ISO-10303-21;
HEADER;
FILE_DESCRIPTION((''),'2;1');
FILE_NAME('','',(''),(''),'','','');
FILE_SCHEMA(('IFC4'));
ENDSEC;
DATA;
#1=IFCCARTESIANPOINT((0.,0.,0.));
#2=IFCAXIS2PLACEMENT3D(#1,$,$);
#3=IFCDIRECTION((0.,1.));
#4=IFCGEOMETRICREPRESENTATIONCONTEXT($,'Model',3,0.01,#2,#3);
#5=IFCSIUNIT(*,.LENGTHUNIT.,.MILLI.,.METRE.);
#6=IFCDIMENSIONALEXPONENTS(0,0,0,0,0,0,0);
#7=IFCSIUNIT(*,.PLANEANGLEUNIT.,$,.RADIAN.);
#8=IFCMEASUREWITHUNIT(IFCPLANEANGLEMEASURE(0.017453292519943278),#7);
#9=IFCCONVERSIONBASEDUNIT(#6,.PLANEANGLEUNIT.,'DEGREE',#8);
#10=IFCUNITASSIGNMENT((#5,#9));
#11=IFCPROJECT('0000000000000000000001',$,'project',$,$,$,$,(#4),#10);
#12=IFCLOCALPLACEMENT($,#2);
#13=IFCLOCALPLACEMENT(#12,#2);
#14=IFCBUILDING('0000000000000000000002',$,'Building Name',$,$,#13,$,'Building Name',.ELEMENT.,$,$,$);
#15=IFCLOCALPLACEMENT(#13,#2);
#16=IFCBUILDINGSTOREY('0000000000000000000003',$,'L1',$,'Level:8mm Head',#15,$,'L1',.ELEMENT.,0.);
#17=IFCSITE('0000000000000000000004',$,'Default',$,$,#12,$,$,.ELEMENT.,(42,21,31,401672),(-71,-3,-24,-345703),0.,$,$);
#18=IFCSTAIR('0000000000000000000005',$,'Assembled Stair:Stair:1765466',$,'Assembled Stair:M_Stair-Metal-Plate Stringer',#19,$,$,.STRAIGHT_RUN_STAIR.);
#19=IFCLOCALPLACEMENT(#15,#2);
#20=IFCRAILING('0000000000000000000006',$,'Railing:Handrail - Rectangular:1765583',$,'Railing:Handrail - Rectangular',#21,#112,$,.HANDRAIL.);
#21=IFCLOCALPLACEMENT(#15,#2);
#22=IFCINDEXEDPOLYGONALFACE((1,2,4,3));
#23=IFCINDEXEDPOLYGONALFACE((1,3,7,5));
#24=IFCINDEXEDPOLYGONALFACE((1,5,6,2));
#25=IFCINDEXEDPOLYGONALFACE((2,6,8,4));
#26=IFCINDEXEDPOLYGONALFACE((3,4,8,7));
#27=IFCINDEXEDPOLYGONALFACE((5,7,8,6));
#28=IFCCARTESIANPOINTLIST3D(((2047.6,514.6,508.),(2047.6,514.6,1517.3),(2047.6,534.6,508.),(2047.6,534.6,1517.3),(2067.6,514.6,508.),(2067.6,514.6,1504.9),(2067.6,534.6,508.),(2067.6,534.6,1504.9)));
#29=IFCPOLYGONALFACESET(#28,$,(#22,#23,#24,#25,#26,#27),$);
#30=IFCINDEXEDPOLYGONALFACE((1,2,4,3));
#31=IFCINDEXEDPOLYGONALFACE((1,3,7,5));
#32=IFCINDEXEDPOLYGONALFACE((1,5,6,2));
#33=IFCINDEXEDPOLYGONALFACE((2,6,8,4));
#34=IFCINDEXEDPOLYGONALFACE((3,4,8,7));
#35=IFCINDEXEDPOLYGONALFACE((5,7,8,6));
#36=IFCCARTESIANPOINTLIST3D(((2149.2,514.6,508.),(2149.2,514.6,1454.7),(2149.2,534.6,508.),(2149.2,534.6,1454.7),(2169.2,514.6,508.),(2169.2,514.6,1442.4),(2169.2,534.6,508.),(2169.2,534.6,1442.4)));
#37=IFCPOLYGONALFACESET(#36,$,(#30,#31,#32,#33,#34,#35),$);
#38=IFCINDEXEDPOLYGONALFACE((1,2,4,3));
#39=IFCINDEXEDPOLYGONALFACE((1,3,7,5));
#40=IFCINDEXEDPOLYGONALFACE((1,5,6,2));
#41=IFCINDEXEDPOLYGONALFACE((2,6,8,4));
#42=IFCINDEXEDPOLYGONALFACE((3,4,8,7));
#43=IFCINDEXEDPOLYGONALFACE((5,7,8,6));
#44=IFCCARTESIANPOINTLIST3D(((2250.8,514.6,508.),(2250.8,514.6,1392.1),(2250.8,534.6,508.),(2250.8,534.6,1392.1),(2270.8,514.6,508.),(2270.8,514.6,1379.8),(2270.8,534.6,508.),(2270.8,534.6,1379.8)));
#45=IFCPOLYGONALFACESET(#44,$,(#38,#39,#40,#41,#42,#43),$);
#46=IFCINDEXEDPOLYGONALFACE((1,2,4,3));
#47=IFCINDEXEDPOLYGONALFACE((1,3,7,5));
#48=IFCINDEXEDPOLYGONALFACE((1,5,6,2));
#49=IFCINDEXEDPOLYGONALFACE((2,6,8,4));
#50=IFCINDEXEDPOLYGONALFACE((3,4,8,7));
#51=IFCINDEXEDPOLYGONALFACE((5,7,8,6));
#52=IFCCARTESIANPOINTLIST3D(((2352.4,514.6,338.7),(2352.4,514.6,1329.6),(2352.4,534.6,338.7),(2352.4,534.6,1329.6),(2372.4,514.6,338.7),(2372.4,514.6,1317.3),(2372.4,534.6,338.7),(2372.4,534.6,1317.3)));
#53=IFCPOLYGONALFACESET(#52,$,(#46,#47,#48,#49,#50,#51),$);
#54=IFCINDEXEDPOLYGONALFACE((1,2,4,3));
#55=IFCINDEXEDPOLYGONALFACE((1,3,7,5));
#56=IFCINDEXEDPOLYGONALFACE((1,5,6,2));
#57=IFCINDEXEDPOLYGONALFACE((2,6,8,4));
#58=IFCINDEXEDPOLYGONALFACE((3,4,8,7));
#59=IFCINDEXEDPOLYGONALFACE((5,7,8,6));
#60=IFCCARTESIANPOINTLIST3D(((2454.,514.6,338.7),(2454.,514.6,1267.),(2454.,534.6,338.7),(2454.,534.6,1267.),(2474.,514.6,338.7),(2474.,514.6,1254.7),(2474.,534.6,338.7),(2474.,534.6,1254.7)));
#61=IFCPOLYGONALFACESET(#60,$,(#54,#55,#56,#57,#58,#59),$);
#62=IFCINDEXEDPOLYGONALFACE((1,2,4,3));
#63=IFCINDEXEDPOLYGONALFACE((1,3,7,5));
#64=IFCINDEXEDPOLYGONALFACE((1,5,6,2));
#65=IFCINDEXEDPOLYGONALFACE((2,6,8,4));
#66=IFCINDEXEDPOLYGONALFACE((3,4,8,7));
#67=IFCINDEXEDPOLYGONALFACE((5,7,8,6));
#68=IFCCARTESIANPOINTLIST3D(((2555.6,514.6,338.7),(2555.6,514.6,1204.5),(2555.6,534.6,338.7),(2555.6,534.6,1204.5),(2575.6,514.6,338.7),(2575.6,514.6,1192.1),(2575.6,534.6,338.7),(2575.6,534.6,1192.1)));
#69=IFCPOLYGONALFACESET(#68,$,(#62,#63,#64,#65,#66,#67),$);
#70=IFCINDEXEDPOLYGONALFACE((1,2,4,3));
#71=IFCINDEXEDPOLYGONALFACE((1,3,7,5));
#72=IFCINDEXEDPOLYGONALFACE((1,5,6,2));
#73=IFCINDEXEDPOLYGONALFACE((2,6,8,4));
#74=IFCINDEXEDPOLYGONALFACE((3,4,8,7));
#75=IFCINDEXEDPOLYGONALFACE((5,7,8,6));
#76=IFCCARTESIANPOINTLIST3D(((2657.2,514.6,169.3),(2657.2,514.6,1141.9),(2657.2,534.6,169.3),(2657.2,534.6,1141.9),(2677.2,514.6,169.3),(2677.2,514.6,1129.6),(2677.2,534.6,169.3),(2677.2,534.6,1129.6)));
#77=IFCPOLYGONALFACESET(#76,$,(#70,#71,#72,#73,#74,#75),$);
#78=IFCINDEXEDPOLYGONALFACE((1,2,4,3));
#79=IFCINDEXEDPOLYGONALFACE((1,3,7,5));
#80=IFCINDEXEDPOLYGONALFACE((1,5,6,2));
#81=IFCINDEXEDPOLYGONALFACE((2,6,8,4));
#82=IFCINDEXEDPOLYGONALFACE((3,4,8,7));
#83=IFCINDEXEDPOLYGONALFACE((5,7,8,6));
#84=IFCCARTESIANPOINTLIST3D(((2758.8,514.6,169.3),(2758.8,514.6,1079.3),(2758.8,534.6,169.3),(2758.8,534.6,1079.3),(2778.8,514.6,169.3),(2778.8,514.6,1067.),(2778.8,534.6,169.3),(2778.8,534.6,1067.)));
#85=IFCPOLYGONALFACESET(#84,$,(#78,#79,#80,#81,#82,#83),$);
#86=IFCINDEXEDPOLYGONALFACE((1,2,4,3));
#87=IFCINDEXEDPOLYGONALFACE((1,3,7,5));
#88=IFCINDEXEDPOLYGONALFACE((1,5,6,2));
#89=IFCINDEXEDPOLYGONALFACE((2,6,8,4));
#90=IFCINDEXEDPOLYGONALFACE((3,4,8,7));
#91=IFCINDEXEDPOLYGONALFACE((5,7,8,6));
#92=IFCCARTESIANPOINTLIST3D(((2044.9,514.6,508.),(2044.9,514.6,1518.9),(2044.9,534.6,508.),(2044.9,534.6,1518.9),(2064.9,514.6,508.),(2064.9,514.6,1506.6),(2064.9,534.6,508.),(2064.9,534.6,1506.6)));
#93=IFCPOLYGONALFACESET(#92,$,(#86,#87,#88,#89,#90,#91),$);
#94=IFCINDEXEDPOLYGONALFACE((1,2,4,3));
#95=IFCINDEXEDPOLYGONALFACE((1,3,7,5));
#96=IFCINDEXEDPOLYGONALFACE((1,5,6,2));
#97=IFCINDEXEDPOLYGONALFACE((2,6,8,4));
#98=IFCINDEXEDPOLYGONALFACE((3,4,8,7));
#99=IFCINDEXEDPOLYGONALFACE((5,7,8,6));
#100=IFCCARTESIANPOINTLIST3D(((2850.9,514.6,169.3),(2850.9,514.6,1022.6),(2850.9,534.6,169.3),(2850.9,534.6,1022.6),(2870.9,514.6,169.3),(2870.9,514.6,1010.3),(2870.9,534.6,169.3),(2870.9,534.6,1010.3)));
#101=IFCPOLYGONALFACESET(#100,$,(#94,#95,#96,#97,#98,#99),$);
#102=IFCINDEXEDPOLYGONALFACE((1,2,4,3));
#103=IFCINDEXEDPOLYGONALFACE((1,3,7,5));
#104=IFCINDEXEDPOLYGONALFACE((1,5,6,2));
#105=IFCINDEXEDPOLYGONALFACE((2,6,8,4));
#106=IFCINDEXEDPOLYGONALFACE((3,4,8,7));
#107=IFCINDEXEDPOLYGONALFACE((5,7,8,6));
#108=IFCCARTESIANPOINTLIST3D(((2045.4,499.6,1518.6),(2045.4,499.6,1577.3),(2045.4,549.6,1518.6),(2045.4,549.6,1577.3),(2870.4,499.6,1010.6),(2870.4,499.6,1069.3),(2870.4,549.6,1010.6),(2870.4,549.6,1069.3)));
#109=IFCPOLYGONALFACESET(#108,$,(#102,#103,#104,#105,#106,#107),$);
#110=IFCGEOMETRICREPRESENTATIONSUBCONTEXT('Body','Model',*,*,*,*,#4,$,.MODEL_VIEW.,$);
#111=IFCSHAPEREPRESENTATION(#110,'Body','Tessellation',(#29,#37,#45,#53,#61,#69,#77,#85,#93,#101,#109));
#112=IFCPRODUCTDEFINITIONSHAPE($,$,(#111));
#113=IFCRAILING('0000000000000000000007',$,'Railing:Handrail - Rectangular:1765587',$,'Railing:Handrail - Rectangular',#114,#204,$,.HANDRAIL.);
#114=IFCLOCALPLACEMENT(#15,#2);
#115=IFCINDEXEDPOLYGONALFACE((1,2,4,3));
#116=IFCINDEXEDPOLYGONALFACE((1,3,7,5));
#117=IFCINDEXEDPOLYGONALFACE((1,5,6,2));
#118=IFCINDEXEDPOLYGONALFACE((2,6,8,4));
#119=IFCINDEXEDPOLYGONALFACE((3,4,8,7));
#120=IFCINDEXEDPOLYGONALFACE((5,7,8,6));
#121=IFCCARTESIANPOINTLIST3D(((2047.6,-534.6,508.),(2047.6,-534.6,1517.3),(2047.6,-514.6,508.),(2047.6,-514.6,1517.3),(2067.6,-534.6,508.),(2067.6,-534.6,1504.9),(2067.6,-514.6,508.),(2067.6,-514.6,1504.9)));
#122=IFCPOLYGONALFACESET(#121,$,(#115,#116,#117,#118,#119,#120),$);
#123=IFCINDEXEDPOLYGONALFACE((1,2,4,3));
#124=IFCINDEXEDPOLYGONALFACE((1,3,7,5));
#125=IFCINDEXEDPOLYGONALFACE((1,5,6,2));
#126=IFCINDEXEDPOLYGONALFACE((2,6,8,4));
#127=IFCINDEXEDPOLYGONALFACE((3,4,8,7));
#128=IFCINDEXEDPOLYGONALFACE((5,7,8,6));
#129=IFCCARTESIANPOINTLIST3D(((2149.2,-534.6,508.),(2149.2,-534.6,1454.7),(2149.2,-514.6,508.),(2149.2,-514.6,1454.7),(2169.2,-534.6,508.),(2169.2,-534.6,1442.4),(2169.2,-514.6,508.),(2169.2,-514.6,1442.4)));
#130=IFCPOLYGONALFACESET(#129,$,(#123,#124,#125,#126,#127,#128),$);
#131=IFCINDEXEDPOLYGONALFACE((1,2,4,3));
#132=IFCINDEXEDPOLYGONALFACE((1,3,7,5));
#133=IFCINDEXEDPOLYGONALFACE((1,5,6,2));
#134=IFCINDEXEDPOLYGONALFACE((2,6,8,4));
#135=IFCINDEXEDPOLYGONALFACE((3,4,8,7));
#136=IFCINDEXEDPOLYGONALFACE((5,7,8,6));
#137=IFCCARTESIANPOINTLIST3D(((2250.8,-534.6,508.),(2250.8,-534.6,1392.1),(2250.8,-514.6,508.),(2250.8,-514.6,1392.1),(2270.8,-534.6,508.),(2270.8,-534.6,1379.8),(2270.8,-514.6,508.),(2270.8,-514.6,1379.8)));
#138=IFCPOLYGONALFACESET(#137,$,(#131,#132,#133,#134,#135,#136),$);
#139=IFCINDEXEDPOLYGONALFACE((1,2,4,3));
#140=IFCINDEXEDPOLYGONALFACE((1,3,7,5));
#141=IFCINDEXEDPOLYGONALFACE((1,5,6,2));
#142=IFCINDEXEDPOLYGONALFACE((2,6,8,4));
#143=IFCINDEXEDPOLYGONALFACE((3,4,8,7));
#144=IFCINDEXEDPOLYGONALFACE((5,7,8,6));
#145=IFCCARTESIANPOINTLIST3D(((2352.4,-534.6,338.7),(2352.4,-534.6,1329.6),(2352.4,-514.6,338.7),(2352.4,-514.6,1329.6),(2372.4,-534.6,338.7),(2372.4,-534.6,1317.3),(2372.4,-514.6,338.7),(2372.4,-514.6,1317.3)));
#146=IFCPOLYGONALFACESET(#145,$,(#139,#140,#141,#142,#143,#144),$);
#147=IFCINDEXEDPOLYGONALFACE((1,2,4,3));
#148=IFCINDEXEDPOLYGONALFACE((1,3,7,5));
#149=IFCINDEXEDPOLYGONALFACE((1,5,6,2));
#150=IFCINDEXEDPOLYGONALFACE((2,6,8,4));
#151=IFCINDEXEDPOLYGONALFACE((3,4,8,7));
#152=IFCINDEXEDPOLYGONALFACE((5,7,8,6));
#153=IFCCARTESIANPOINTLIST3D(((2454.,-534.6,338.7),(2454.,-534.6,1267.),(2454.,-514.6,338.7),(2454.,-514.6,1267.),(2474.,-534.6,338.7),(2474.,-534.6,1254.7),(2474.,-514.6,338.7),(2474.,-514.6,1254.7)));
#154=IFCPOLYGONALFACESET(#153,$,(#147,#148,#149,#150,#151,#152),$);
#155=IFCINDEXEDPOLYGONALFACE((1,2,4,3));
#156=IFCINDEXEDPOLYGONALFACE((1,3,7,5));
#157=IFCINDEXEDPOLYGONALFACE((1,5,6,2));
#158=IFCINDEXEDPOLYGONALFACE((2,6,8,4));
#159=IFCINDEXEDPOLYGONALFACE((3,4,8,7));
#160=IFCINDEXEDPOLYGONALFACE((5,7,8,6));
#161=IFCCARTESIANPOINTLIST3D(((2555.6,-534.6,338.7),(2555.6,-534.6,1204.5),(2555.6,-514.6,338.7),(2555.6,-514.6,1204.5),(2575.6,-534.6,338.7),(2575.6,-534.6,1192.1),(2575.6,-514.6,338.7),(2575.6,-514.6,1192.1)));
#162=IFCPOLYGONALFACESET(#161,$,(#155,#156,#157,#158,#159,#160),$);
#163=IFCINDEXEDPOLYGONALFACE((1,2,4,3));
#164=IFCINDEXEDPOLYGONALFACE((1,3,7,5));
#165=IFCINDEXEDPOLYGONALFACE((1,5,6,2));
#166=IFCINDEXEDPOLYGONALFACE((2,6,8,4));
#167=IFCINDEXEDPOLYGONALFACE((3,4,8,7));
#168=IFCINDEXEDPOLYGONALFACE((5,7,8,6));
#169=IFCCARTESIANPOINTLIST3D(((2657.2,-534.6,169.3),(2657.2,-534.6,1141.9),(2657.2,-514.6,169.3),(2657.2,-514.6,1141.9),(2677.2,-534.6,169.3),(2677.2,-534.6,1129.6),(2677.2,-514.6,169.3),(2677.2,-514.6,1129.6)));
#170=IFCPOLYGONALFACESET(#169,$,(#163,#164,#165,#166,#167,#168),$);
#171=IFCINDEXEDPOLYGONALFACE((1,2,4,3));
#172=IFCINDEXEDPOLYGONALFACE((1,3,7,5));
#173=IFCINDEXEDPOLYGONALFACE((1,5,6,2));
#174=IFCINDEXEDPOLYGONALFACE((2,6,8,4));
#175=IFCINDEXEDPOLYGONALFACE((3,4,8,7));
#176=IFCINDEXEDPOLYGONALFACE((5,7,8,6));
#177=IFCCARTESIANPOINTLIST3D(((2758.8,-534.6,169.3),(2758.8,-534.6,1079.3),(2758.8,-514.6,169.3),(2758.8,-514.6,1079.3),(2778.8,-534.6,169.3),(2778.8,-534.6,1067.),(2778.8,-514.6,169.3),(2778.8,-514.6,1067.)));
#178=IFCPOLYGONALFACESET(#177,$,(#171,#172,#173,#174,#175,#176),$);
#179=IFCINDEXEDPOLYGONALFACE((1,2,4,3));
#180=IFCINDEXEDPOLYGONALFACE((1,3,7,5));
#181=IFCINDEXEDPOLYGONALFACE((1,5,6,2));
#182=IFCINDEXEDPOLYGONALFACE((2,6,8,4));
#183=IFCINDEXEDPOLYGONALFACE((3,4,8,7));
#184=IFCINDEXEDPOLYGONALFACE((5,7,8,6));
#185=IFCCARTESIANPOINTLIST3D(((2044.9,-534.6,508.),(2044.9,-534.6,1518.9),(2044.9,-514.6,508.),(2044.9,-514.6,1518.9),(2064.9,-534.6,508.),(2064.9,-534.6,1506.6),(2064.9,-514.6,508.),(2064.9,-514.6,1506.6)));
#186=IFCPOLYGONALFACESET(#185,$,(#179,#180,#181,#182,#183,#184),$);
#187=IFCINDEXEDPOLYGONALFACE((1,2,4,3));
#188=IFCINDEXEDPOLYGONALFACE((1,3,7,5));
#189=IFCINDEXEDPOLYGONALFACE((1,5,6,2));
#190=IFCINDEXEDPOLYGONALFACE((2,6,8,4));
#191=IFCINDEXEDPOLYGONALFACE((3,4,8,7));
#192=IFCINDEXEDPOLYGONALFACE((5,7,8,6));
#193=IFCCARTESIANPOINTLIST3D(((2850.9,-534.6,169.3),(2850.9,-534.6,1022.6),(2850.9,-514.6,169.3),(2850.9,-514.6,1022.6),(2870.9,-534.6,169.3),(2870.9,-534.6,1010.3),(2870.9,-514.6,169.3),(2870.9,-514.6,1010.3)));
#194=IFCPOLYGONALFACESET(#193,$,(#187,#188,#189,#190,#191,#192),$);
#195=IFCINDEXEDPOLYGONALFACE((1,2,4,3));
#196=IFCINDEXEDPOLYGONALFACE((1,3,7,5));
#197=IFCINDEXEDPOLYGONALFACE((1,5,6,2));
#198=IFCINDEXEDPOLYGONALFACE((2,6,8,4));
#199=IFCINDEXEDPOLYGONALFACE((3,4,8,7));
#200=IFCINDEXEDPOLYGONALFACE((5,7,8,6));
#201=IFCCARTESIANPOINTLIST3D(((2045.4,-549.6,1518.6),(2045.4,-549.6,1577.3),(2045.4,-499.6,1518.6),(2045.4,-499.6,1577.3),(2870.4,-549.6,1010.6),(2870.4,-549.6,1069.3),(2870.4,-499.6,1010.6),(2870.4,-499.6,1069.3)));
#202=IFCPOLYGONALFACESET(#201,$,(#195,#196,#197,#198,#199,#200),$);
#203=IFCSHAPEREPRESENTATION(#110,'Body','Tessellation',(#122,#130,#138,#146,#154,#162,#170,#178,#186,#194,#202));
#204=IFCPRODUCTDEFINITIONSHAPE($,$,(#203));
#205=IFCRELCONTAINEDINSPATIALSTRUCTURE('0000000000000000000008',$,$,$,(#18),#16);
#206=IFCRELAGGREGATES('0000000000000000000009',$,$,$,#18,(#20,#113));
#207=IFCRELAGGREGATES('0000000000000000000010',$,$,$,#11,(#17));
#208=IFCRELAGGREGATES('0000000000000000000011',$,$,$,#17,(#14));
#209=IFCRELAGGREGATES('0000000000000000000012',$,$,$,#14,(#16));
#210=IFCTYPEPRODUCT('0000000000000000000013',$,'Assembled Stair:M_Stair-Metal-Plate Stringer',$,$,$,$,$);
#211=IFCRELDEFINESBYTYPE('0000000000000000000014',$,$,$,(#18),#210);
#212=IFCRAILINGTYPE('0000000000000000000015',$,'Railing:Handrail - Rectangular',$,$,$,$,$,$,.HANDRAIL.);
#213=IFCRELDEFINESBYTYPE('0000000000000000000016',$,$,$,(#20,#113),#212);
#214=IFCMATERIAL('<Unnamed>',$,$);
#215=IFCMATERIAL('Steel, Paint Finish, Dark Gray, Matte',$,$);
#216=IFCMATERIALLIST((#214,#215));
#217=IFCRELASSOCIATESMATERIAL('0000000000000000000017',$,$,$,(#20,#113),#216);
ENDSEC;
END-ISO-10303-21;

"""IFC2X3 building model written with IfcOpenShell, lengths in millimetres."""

from ifc_helpers import new_model, entity, si_unit, converted_unit, direction, frame, origin, place, context, subcontext, project, spatial, polyline, outline, extrude, material, material_list, type_object, element, aggregate, save


model = new_model("IFC2X3")

# Units and contexts
model_context = context("Model", 3, precision=0.01, world=origin(), true_north=direction((0.0, 1.0)))
body_context = subcontext(model_context, "Body", "Model", "MODEL_VIEW")
ifc_project = project(units=[si_unit("LENGTHUNIT", "METRE", prefix="MILLI"), converted_unit("PLANEANGLEUNIT", "DEGREE", entity("IfcPlaneAngleMeasure", 0.017453292519943278), si_unit("PLANEANGLEUNIT", "RADIAN"), dimensions=[0, 0, 0, 0, 0, 0, 0])], contexts=[model_context])

# Site, building, storey
site_placement = place(None, origin())
site = spatial("IfcSite", under=ifc_project, at=site_placement, Name="Default", CompositionType="ELEMENT", RefLatitude=(42, 21, 31, 401672), RefLongitude=(-71, -3, -24, -345703), RefElevation=0.0)
building_placement = place(site_placement, origin())
building = spatial("IfcBuilding", under=site, at=building_placement, Name="Building Name", LongName="Building Name", CompositionType="ELEMENT")
storey_placement = place(building_placement, origin())
storey = spatial("IfcBuildingStorey", under=building, at=storey_placement, Name="L1", ObjectType="Level:8mm Head", LongName="L1", CompositionType="ELEMENT", Elevation=0.0)

# Stair
type_product = type_object("IfcTypeProduct", Name="Assembled Stair:M_Stair-Metal-Plate Stringer")
stair_1_placement = place(storey_placement, origin())
stair_1 = element("IfcStair", 1, at=stair_1_placement, inside=storey, type_object=type_product, Name="Assembled Stair:Stair:1765466", ObjectType="Assembled Stair:M_Stair-Metal-Plate Stringer", ShapeType="STRAIGHT_RUN_STAIR")

# Railings
ifc_material_1 = material(Name="<Unnamed>")
ifc_material_2 = material(Name="Steel, Paint Finish, Dark Gray, Matte")
ifc_material_list = material_list([ifc_material_1, ifc_material_2])
railing_type = type_object("IfcRailingType", Name="Railing:Handrail - Rectangular", PredefinedType="HANDRAIL")
railing_1_placement = place(stair_1_placement, origin())
railing_1 = element("IfcRailing", 2, at=railing_1_placement, type_object=railing_type, material=ifc_material_list, Name="Railing:Handrail - Rectangular:1765583", ObjectType="Railing:Handrail - Rectangular", PredefinedType="HANDRAIL", context=body_context, shape_type="SweptSolid", body=[
    extrude(outline(polyline([(-10.0, -501.6), (10.0, -501.6), (10.0, 507.7), (-10.0, 495.4), (-10.0, -501.6)])), frame((2057.6, 514.6, 1009.6), z_axis=(0.0, 1.0, 0.0), x_axis=(-1.0, 0.0, 0.0)), (0.0, 0.0, 1.0), 20.0),
    extrude(outline(polyline([(-10.0, -470.3), (10.0, -470.3), (10.0, 476.4), (-10.0, 464.1), (-10.0, -470.3)])), frame((2159.2, 514.6, 978.3), z_axis=(0.0, 1.0, 0.0), x_axis=(-1.0, 0.0, 0.0)), (0.0, 0.0, 1.0), 20.0),
    extrude(outline(polyline([(-10.0, -439.0), (10.0, -439.0), (10.0, 445.1), (-10.0, 432.8), (-10.0, -439.0)])), frame((2260.8, 514.6, 947.0), z_axis=(0.0, 1.0, 0.0), x_axis=(-1.0, 0.0, 0.0)), (0.0, 0.0, 1.0), 20.0),
    extrude(outline(polyline([(-10.0, -492.4), (10.0, -492.4), (10.0, 498.5), (-10.0, 486.2), (-10.0, -492.4)])), frame((2362.4, 514.6, 831.0), z_axis=(0.0, 1.0, 0.0), x_axis=(-1.0, 0.0, 0.0)), (0.0, 0.0, 1.0), 20.0),
    extrude(outline(polyline([(-10.0, -461.1), (10.0, -461.1), (10.0, 467.3), (-10.0, 454.9), (-10.0, -461.1)])), frame((2464.0, 514.6, 799.8), z_axis=(0.0, 1.0, 0.0), x_axis=(-1.0, 0.0, 0.0)), (0.0, 0.0, 1.0), 20.0),
    extrude(outline(polyline([(-10.0, -429.8), (10.0, -429.8), (10.0, 436.0), (-10.0, 423.7), (-10.0, -429.8)])), frame((2565.6, 514.6, 768.5), z_axis=(0.0, 1.0, 0.0), x_axis=(-1.0, 0.0, 0.0)), (0.0, 0.0, 1.0), 20.0),
    extrude(outline(polyline([(-10.0, -483.2), (10.0, -483.2), (10.0, 489.4), (-10.0, 477.0), (-10.0, -483.2)])), frame((2667.2, 514.6, 652.5), z_axis=(0.0, 1.0, 0.0), x_axis=(-1.0, 0.0, 0.0)), (0.0, 0.0, 1.0), 20.0),
    extrude(outline(polyline([(-10.0, -451.9), (10.0, -451.9), (10.0, 458.1), (-10.0, 445.8), (-10.0, -451.9)])), frame((2768.8, 514.6, 621.3), z_axis=(0.0, 1.0, 0.0), x_axis=(-1.0, 0.0, 0.0)), (0.0, 0.0, 1.0), 20.0),
    extrude(outline(polyline([(-10.0, -502.4), (10.0, -502.4), (10.0, 508.5), (-10.0, 496.2), (-10.0, -502.4)])), frame((2054.9, 514.6, 1010.4), z_axis=(0.0, 1.0, 0.0), x_axis=(-1.0, 0.0, 0.0)), (0.0, 0.0, 1.0), 20.0),
    extrude(outline(polyline([(-10.0, -423.6), (10.0, -423.6), (10.0, 429.7), (-10.0, 417.4), (-10.0, -423.6)])), frame((2860.9, 514.6, 592.9), z_axis=(0.0, 1.0, 0.0), x_axis=(-1.0, 0.0, 0.0)), (0.0, 0.0, 1.0), 20.0),
    extrude(outline(polyline([(-499.8, -25.0), (469.0, -25.0), (499.8, 25.0), (-469.0, 25.0), (-499.8, -25.0)])), frame((2457.9, 499.6, 1294.0), z_axis=(0.0, 1.0, 0.0), x_axis=(-0.851517, 0.0, 0.524328)), (0.0, 0.0, 1.0), 50.0),
])
railing_2_placement = place(stair_1_placement, origin())
railing_2 = element("IfcRailing", 3, at=railing_2_placement, type_object=railing_type, material=ifc_material_list, Name="Railing:Handrail - Rectangular:1765587", ObjectType="Railing:Handrail - Rectangular", PredefinedType="HANDRAIL", context=body_context, shape_type="SweptSolid", body=[
    extrude(outline(polyline([(-495.4, -10.0), (501.6, -10.0), (501.6, 10.0), (-507.7, 10.0), (-495.4, -10.0)])), frame((2057.6, -534.6, 1009.6), z_axis=(0.0, 1.0, 0.0), x_axis=(0.0, 0.0, -1.0)), (0.0, 0.0, 1.0), 20.0),
    extrude(outline(polyline([(-464.1, -10.0), (470.3, -10.0), (470.3, 10.0), (-476.4, 10.0), (-464.1, -10.0)])), frame((2159.2, -534.6, 978.3), z_axis=(0.0, 1.0, 0.0), x_axis=(0.0, 0.0, -1.0)), (0.0, 0.0, 1.0), 20.0),
    extrude(outline(polyline([(-432.8, -10.0), (439.0, -10.0), (439.0, 10.0), (-445.1, 10.0), (-432.8, -10.0)])), frame((2260.8, -534.6, 947.0), z_axis=(0.0, 1.0, 0.0), x_axis=(0.0, 0.0, -1.0)), (0.0, 0.0, 1.0), 20.0),
    extrude(outline(polyline([(-486.2, -10.0), (492.4, -10.0), (492.4, 10.0), (-498.5, 10.0), (-486.2, -10.0)])), frame((2362.4, -534.6, 831.0), z_axis=(0.0, 1.0, 0.0), x_axis=(0.0, 0.0, -1.0)), (0.0, 0.0, 1.0), 20.0),
    extrude(outline(polyline([(-454.9, -10.0), (461.1, -10.0), (461.1, 10.0), (-467.3, 10.0), (-454.9, -10.0)])), frame((2464.0, -534.6, 799.8), z_axis=(0.0, 1.0, 0.0), x_axis=(0.0, 0.0, -1.0)), (0.0, 0.0, 1.0), 20.0),
    extrude(outline(polyline([(-423.7, -10.0), (429.8, -10.0), (429.8, 10.0), (-436.0, 10.0), (-423.7, -10.0)])), frame((2565.6, -534.6, 768.5), z_axis=(0.0, 1.0, 0.0), x_axis=(0.0, 0.0, -1.0)), (0.0, 0.0, 1.0), 20.0),
    extrude(outline(polyline([(-477.0, -10.0), (483.2, -10.0), (483.2, 10.0), (-489.4, 10.0), (-477.0, -10.0)])), frame((2667.2, -534.6, 652.5), z_axis=(0.0, 1.0, 0.0), x_axis=(0.0, 0.0, -1.0)), (0.0, 0.0, 1.0), 20.0),
    extrude(outline(polyline([(-445.8, -10.0), (451.9, -10.0), (451.9, 10.0), (-458.1, 10.0), (-445.8, -10.0)])), frame((2768.8, -534.6, 621.3), z_axis=(0.0, 1.0, 0.0), x_axis=(0.0, 0.0, -1.0)), (0.0, 0.0, 1.0), 20.0),
    extrude(outline(polyline([(-496.2, -10.0), (502.4, -10.0), (502.4, 10.0), (-508.5, 10.0), (-496.2, -10.0)])), frame((2054.9, -534.6, 1010.4), z_axis=(0.0, 1.0, 0.0), x_axis=(0.0, 0.0, -1.0)), (0.0, 0.0, 1.0), 20.0),
    extrude(outline(polyline([(-417.4, -10.0), (423.6, -10.0), (423.6, 10.0), (-429.7, 10.0), (-417.4, -10.0)])), frame((2860.9, -534.6, 592.9), z_axis=(0.0, 1.0, 0.0), x_axis=(0.0, 0.0, -1.0)), (0.0, 0.0, 1.0), 20.0),
    extrude(outline(polyline([(-499.8, -25.0), (469.0, -25.0), (499.8, 25.0), (-469.0, 25.0), (-499.8, -25.0)])), frame((2457.9, -549.6, 1294.0), z_axis=(0.0, 1.0, 0.0), x_axis=(-0.851517, 0.0, 0.524328)), (0.0, 0.0, 1.0), 50.0),
])
aggregate(stair_1, [railing_1, railing_2])

save(model, "model.ifc")
